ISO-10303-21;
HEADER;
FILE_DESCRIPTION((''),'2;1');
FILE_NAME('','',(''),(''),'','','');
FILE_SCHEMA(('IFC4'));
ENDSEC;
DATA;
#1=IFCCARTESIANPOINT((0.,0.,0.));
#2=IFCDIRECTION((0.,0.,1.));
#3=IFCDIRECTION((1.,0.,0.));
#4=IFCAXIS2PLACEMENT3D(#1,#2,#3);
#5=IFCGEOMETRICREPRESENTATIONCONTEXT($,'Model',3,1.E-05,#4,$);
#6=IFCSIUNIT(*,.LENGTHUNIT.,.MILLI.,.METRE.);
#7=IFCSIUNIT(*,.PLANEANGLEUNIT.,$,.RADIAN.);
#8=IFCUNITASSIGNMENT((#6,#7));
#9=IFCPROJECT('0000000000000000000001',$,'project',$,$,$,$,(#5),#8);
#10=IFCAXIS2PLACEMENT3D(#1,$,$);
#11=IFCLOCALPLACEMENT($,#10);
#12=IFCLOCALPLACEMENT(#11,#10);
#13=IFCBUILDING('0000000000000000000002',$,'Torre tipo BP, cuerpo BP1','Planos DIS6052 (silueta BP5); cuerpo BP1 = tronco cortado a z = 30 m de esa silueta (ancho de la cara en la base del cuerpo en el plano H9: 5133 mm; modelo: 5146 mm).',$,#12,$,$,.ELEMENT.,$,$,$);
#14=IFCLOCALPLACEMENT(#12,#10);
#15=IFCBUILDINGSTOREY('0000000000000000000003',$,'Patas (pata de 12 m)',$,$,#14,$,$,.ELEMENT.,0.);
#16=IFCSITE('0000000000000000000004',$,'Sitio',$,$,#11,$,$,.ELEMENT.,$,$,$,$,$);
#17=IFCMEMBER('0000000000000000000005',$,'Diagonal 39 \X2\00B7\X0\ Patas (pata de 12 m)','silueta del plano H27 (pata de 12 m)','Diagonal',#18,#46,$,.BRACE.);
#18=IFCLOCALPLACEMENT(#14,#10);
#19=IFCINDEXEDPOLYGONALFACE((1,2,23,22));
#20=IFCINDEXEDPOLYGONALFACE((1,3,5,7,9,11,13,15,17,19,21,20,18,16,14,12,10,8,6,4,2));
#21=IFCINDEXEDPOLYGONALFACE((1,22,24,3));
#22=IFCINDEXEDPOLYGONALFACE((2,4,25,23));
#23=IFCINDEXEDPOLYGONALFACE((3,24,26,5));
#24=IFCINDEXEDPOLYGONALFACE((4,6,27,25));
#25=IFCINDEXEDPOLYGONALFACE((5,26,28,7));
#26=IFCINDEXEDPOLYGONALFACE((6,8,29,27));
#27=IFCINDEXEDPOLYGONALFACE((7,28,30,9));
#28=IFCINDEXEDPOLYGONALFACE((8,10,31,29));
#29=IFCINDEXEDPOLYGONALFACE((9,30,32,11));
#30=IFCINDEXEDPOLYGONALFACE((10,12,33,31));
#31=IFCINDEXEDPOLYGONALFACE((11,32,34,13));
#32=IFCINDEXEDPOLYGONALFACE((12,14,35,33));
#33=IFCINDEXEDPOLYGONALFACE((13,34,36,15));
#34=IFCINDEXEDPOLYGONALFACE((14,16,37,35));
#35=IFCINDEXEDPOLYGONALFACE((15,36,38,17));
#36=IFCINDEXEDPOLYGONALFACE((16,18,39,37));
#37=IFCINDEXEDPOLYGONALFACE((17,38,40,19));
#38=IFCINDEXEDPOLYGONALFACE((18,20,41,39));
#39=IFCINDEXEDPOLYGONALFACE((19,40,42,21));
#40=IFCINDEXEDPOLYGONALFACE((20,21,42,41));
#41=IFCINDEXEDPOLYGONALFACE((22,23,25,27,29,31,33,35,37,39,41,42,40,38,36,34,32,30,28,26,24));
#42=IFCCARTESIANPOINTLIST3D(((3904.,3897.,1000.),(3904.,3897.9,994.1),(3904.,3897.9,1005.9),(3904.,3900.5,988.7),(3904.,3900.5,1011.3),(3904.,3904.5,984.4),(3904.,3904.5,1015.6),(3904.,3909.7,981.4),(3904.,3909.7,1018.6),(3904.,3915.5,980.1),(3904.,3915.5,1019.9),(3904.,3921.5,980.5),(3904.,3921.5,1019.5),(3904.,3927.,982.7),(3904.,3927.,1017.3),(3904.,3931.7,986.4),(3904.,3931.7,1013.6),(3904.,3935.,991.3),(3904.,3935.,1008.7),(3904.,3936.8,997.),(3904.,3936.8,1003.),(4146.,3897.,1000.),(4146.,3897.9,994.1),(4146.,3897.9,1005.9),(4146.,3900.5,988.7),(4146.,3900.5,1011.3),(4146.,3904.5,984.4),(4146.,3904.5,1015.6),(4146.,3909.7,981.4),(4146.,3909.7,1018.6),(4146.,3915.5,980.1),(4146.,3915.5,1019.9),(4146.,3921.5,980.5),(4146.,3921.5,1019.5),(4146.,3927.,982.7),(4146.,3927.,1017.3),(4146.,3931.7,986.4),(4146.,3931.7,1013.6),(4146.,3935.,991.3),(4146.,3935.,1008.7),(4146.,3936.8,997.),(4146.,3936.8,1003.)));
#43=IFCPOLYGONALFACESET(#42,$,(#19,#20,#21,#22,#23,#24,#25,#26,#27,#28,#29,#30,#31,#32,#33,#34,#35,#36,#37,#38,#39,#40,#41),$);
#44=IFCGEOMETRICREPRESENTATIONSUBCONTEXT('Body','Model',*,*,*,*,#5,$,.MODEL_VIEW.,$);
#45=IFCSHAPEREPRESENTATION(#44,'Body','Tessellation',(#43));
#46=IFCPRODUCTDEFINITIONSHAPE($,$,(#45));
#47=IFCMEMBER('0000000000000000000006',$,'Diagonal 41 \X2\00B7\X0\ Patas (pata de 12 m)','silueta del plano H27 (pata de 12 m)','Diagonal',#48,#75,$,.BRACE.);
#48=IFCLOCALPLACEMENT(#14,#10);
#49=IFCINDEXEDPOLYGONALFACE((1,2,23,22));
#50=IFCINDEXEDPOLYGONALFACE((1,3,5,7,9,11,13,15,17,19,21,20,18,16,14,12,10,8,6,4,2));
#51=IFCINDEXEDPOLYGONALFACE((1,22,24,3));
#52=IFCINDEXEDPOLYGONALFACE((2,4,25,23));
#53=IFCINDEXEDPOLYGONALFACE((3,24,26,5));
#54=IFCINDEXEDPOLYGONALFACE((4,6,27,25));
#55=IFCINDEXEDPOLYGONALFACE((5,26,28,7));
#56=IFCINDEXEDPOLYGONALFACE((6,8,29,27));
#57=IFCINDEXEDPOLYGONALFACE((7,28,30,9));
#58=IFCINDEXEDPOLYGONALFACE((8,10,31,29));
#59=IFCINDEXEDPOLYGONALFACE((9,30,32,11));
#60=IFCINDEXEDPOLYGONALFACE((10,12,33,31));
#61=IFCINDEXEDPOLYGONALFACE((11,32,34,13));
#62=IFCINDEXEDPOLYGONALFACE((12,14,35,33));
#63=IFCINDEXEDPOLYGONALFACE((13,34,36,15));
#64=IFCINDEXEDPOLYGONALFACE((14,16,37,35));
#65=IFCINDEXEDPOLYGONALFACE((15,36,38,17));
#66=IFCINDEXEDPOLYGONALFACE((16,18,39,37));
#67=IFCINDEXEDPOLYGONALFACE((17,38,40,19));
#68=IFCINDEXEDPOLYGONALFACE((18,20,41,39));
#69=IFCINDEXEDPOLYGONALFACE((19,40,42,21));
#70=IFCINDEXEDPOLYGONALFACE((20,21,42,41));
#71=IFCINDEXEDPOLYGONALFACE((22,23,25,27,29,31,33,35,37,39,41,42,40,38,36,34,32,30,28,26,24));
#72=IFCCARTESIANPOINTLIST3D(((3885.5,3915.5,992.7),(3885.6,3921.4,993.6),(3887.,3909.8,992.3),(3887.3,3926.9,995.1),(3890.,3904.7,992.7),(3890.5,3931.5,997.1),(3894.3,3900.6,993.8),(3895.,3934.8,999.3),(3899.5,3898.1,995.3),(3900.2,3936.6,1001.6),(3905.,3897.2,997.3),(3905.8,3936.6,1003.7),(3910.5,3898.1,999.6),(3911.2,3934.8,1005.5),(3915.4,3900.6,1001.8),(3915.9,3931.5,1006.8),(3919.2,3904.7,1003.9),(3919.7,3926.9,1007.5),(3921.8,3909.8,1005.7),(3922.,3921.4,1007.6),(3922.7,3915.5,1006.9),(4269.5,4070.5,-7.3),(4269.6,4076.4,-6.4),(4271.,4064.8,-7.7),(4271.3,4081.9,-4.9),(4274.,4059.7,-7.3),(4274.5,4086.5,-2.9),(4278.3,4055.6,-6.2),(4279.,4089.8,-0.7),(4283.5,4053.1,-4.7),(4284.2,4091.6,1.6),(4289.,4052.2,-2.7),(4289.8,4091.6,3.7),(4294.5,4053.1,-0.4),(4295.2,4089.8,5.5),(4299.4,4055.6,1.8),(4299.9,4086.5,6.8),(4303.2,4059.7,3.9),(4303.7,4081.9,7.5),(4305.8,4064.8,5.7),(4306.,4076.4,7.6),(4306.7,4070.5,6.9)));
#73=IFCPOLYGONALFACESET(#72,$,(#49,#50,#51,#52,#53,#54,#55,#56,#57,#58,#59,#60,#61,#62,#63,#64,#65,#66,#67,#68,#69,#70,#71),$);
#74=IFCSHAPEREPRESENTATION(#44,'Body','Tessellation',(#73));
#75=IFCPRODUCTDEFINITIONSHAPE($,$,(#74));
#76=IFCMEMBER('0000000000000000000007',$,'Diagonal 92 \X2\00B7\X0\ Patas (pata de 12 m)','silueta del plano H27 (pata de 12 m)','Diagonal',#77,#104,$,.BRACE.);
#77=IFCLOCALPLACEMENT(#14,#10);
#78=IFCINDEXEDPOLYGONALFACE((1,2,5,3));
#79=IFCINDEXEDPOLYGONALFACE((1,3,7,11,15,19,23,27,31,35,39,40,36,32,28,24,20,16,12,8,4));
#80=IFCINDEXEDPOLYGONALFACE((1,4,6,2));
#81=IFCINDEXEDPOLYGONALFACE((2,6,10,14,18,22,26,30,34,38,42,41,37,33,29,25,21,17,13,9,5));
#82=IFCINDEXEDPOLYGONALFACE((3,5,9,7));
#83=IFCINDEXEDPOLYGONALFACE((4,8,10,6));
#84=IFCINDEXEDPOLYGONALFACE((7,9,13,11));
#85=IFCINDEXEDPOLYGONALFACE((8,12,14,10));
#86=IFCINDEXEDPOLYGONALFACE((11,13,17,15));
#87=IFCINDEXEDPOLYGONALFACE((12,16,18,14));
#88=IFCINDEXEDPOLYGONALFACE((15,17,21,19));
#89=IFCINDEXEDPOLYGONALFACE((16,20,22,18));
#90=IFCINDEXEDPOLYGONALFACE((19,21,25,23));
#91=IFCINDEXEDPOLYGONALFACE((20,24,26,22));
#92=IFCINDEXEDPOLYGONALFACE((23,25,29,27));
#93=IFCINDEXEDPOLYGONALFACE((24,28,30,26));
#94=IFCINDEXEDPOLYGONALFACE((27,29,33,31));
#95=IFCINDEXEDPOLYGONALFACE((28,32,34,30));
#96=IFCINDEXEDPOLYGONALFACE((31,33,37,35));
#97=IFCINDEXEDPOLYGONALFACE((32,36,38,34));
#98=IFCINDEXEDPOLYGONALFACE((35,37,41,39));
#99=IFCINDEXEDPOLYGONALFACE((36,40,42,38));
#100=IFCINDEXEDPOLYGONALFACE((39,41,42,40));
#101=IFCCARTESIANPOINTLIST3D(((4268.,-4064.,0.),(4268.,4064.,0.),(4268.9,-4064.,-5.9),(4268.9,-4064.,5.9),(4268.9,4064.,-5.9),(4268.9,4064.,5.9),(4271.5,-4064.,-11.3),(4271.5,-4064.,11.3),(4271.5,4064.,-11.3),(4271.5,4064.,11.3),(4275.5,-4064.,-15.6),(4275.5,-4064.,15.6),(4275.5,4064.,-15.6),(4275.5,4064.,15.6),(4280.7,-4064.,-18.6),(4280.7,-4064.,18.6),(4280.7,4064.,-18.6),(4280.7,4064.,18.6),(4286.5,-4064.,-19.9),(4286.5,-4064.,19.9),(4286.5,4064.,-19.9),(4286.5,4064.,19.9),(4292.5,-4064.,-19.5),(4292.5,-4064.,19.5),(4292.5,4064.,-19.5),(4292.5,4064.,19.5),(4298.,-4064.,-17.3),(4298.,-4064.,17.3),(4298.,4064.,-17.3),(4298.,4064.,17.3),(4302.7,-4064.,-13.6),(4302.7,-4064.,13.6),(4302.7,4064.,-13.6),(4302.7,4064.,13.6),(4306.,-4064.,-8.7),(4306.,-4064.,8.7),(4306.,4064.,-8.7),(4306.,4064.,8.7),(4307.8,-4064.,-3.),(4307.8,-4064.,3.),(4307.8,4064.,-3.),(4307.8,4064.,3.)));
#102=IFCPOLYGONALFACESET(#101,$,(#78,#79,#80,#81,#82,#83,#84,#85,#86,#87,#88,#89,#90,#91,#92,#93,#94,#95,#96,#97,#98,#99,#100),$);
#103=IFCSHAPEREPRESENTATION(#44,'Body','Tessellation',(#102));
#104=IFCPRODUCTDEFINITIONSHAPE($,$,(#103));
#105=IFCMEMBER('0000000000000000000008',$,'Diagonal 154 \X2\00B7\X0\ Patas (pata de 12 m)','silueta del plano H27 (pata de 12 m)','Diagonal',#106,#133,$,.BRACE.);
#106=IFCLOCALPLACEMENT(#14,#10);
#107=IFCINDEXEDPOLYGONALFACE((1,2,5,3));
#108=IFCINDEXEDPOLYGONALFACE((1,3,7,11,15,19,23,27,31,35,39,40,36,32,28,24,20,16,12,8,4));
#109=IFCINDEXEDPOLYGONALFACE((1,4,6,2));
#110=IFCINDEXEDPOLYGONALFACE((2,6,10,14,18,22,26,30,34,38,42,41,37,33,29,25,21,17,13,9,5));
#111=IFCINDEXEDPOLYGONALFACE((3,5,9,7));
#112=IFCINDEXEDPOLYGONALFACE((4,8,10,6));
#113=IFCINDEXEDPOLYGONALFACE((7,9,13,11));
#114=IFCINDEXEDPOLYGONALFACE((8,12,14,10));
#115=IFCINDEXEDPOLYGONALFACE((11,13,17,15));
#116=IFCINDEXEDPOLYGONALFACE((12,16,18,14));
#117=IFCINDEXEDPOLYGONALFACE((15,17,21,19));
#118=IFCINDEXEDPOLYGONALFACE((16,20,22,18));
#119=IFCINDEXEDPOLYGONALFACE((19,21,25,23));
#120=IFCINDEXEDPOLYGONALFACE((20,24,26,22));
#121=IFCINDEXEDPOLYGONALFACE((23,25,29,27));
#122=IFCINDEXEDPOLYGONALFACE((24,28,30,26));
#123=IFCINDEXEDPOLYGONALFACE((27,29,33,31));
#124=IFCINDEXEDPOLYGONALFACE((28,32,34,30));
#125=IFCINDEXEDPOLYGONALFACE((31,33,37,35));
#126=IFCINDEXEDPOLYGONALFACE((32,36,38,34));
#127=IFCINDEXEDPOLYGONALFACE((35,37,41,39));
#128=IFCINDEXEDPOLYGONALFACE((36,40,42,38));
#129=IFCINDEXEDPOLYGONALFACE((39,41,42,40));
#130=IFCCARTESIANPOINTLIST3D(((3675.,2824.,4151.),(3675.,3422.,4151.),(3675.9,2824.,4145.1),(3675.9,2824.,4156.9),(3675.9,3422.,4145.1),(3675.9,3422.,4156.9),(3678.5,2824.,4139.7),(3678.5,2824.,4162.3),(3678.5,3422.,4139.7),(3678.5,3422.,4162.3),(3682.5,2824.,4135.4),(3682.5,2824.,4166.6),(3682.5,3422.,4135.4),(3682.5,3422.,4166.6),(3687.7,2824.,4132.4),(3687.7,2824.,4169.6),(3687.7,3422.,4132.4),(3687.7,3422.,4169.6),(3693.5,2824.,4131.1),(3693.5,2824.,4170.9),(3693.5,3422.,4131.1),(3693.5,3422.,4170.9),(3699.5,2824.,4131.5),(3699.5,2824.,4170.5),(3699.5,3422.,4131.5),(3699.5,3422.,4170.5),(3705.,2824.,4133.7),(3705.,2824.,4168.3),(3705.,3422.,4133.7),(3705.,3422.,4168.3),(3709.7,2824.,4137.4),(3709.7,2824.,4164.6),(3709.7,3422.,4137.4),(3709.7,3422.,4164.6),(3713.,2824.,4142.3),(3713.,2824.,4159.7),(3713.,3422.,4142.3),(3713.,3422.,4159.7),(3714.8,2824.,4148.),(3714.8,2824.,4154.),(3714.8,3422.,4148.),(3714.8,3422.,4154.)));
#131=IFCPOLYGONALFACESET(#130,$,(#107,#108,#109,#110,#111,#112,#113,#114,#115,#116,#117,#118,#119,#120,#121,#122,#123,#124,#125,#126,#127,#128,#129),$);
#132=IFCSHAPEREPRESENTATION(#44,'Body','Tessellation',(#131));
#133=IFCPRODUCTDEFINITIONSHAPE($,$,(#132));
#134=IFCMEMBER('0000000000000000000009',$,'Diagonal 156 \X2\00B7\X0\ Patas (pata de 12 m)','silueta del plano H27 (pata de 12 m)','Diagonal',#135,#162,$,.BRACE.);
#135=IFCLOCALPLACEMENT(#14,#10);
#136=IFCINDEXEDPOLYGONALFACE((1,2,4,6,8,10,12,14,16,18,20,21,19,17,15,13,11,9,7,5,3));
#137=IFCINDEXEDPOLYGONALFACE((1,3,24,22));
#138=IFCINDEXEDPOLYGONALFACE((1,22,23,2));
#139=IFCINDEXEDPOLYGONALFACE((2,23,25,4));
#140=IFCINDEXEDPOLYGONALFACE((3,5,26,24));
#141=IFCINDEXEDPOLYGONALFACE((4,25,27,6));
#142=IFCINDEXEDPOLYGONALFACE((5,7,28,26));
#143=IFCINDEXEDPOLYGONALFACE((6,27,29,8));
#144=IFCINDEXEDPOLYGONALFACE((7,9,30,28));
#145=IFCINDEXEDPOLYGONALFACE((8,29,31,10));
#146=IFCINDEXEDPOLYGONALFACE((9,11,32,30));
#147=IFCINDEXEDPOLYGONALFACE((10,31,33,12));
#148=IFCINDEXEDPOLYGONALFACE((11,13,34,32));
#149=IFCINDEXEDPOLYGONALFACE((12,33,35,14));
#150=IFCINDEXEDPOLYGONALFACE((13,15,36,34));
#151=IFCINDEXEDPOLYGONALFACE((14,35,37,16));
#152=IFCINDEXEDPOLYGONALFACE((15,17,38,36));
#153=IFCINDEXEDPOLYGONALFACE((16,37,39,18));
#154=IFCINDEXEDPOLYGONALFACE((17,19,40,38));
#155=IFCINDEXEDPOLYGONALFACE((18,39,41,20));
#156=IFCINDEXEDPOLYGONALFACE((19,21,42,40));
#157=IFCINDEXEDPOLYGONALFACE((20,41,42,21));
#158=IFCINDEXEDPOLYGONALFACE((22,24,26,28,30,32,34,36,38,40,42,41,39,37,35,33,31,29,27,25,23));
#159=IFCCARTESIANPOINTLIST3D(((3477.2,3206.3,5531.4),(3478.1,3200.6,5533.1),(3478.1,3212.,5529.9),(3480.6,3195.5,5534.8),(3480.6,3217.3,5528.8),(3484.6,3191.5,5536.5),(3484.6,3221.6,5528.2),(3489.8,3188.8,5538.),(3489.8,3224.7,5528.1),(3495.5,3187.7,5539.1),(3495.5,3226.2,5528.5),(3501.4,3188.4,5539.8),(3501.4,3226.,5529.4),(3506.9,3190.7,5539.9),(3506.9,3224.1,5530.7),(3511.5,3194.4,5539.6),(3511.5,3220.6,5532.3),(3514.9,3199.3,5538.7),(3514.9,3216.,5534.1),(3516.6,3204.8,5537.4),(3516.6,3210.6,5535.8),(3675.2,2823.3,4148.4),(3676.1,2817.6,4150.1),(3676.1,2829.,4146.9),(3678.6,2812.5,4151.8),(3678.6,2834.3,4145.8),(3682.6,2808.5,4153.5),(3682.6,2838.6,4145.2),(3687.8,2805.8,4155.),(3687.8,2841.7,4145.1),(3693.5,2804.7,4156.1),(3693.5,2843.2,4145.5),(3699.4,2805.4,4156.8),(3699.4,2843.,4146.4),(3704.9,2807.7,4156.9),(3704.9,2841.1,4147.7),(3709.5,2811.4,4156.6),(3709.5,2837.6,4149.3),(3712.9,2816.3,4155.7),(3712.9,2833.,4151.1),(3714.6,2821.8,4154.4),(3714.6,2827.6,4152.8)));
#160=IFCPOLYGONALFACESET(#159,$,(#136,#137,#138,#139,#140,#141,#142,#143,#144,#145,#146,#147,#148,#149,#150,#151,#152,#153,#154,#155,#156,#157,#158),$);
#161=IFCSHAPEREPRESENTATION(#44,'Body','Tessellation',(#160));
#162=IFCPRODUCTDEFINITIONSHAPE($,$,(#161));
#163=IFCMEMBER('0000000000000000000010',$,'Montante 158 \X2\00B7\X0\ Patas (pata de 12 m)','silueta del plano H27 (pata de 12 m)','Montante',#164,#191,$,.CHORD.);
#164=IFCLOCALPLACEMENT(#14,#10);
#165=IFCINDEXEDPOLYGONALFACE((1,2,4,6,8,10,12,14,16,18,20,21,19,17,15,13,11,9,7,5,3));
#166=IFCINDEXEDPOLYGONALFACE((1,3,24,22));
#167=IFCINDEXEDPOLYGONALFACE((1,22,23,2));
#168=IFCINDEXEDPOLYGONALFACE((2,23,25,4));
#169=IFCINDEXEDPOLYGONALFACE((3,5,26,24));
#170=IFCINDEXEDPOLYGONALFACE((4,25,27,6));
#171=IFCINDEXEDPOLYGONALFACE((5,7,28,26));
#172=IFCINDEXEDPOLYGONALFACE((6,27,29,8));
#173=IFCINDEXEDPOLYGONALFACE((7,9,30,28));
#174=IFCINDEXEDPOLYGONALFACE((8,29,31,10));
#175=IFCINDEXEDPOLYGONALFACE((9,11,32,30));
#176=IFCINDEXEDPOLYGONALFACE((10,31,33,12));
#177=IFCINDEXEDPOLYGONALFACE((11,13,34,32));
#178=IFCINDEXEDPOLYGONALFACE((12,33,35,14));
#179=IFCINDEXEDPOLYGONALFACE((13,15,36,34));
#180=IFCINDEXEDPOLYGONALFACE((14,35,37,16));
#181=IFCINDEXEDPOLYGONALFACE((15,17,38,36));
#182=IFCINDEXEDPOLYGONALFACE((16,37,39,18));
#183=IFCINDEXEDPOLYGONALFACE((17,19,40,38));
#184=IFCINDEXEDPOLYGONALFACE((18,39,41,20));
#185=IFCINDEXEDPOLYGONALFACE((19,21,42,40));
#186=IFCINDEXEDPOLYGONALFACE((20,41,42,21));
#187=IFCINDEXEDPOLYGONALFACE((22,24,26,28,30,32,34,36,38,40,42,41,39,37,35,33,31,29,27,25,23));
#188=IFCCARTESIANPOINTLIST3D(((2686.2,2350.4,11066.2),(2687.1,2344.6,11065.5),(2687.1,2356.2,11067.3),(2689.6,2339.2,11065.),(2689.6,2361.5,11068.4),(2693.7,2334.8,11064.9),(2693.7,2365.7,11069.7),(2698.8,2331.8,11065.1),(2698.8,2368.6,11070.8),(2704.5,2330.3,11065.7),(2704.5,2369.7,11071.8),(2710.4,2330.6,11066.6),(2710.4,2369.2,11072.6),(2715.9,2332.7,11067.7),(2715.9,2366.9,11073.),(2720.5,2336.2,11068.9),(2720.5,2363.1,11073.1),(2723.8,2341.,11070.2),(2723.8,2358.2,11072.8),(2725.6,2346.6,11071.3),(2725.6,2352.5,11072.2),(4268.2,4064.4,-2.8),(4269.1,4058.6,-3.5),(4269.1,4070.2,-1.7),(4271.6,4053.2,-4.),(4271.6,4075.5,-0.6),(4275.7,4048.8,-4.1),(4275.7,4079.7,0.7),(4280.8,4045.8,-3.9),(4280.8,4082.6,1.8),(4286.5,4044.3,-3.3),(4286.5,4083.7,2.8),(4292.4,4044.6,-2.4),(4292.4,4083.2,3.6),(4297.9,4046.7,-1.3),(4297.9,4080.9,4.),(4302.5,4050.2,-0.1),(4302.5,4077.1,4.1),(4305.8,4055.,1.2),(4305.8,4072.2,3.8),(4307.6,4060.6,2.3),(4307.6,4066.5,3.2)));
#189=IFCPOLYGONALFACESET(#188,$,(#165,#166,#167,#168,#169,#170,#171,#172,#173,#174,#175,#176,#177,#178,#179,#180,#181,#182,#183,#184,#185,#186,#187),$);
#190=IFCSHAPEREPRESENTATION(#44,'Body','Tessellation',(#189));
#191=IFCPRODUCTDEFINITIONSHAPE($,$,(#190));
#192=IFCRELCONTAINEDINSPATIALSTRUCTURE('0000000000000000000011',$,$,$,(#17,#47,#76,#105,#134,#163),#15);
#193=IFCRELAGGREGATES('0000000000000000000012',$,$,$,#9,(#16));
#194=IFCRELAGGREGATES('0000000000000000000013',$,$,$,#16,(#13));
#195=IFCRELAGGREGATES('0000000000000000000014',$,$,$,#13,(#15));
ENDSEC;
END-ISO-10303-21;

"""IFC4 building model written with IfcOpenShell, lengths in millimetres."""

from ifc_helpers import new_model, si_unit, frame, origin, origin_with_axes, place, context, subcontext, project, spatial, circle, extrude, element, save


model = new_model("IFC4")

# Units and contexts
model_context = context("Model", 3, precision=1e-05, world=origin_with_axes())
body_context = subcontext(model_context, "Body", "Model", "MODEL_VIEW")
ifc_project = project(units=[si_unit("LENGTHUNIT", "METRE", prefix="MILLI"), si_unit("PLANEANGLEUNIT", "RADIAN")], contexts=[model_context])

# Site, building, storey
site_placement = place(None, origin())
site = spatial("IfcSite", under=ifc_project, at=site_placement, Name="Sitio", CompositionType="ELEMENT")
building_placement = place(site_placement, origin())
building = spatial("IfcBuilding", under=site, at=building_placement, Name="Torre tipo BP, cuerpo BP1", Description="Planos DIS6052 (silueta BP5); cuerpo BP1 = tronco cortado a z = 30 m de esa silueta (ancho de la cara en la base del cuerpo en el plano H9: 5133 mm; modelo: 5146 mm).", CompositionType="ELEMENT")
storey_placement = place(building_placement, origin())
storey = spatial("IfcBuildingStorey", under=building, at=storey_placement, Name="Patas (pata de 12 m)", CompositionType="ELEMENT", Elevation=0.0)

# Members
member_1_placement = place(storey_placement, frame((4146.0, 3917.0, 1000.0), z_axis=(-1.0, 0.0, 0.0), x_axis=(0.0, -1.0, 0.0)))
element("IfcMember", 1, at=member_1_placement, inside=storey, Name="Diagonal 39 · Patas (pata de 12 m)", Description="silueta del plano H27 (pata de 12 m)", ObjectType="Diagonal", PredefinedType="BRACE", context=body_context, shape_type="SweptSolid", body=[
    extrude(circle(Radius=20.0), None, (0.0, 0.0, 1.0), 242.0),
])
member_2_placement = place(storey_placement, frame((4288.0, 4072.0, 0.0), z_axis=(-0.354784, -0.143207, 0.923916), x_axis=(0.051337, -0.989693, -0.133689)))
element("IfcMember", 2, at=member_2_placement, inside=storey, Name="Diagonal 41 · Patas (pata de 12 m)", Description="silueta del plano H27 (pata de 12 m)", ObjectType="Diagonal", PredefinedType="BRACE", context=body_context, shape_type="SweptSolid", body=[
    extrude(circle(Radius=20.0), None, (0.0, 0.0, 1.0), 1082.3),
])
member_3_placement = place(storey_placement, frame((4288.0, 4064.0, 0.0), z_axis=(0.0, -1.0, 0.0), x_axis=(-1.0, 0.0, 0.0)))
element("IfcMember", 3, at=member_3_placement, inside=storey, Name="Diagonal 92 · Patas (pata de 12 m)", Description="silueta del plano H27 (pata de 12 m)", ObjectType="Diagonal", PredefinedType="BRACE", context=body_context, shape_type="SweptSolid", body=[
    extrude(circle(Radius=20.0), None, (0.0, 0.0, 1.0), 8128.0),
])
member_4_placement = place(storey_placement, frame((3695.0, 3422.0, 4151.0), z_axis=(0.0, -1.0, 0.0), x_axis=(-1.0, 0.0, 0.0)))
element("IfcMember", 4, at=member_4_placement, inside=storey, Name="Diagonal 154 · Patas (pata de 12 m)", Description="silueta del plano H27 (pata de 12 m)", ObjectType="Diagonal", PredefinedType="BRACE", context=body_context, shape_type="SweptSolid", body=[
    extrude(circle(Radius=20.0), None, (0.0, 0.0, 1.0), 598.0),
])
member_5_placement = place(storey_placement, frame((3695.0, 2824.0, 4151.0), z_axis=(-0.136679, 0.264384, 0.954683), x_axis=(-0.990615, -0.036478, -0.131721)))
element("IfcMember", 5, at=member_5_placement, inside=storey, Name="Diagonal 156 · Patas (pata de 12 m)", Description="silueta del plano H27 (pata de 12 m)", ObjectType="Diagonal", PredefinedType="BRACE", context=body_context, shape_type="SweptSolid", body=[
    extrude(circle(Radius=20.0), None, (0.0, 0.0, 1.0), 1448.6),
])
member_6_placement = place(storey_placement, frame((4288.0, 4064.0, 0.0), z_axis=(-0.13985, -0.151519, 0.978511), x_axis=(-0.990173, 0.0214, -0.138203)))
element("IfcMember", 6, at=member_6_placement, inside=storey, Name="Montante 158 · Patas (pata de 12 m)", Description="silueta del plano H27 (pata de 12 m)", ObjectType="Montante", PredefinedType="CHORD", context=body_context, shape_type="SweptSolid", body=[
    extrude(circle(Radius=20.0), None, (0.0, 0.0, 1.0), 11312.1),
])

save(model, "model.ifc")
